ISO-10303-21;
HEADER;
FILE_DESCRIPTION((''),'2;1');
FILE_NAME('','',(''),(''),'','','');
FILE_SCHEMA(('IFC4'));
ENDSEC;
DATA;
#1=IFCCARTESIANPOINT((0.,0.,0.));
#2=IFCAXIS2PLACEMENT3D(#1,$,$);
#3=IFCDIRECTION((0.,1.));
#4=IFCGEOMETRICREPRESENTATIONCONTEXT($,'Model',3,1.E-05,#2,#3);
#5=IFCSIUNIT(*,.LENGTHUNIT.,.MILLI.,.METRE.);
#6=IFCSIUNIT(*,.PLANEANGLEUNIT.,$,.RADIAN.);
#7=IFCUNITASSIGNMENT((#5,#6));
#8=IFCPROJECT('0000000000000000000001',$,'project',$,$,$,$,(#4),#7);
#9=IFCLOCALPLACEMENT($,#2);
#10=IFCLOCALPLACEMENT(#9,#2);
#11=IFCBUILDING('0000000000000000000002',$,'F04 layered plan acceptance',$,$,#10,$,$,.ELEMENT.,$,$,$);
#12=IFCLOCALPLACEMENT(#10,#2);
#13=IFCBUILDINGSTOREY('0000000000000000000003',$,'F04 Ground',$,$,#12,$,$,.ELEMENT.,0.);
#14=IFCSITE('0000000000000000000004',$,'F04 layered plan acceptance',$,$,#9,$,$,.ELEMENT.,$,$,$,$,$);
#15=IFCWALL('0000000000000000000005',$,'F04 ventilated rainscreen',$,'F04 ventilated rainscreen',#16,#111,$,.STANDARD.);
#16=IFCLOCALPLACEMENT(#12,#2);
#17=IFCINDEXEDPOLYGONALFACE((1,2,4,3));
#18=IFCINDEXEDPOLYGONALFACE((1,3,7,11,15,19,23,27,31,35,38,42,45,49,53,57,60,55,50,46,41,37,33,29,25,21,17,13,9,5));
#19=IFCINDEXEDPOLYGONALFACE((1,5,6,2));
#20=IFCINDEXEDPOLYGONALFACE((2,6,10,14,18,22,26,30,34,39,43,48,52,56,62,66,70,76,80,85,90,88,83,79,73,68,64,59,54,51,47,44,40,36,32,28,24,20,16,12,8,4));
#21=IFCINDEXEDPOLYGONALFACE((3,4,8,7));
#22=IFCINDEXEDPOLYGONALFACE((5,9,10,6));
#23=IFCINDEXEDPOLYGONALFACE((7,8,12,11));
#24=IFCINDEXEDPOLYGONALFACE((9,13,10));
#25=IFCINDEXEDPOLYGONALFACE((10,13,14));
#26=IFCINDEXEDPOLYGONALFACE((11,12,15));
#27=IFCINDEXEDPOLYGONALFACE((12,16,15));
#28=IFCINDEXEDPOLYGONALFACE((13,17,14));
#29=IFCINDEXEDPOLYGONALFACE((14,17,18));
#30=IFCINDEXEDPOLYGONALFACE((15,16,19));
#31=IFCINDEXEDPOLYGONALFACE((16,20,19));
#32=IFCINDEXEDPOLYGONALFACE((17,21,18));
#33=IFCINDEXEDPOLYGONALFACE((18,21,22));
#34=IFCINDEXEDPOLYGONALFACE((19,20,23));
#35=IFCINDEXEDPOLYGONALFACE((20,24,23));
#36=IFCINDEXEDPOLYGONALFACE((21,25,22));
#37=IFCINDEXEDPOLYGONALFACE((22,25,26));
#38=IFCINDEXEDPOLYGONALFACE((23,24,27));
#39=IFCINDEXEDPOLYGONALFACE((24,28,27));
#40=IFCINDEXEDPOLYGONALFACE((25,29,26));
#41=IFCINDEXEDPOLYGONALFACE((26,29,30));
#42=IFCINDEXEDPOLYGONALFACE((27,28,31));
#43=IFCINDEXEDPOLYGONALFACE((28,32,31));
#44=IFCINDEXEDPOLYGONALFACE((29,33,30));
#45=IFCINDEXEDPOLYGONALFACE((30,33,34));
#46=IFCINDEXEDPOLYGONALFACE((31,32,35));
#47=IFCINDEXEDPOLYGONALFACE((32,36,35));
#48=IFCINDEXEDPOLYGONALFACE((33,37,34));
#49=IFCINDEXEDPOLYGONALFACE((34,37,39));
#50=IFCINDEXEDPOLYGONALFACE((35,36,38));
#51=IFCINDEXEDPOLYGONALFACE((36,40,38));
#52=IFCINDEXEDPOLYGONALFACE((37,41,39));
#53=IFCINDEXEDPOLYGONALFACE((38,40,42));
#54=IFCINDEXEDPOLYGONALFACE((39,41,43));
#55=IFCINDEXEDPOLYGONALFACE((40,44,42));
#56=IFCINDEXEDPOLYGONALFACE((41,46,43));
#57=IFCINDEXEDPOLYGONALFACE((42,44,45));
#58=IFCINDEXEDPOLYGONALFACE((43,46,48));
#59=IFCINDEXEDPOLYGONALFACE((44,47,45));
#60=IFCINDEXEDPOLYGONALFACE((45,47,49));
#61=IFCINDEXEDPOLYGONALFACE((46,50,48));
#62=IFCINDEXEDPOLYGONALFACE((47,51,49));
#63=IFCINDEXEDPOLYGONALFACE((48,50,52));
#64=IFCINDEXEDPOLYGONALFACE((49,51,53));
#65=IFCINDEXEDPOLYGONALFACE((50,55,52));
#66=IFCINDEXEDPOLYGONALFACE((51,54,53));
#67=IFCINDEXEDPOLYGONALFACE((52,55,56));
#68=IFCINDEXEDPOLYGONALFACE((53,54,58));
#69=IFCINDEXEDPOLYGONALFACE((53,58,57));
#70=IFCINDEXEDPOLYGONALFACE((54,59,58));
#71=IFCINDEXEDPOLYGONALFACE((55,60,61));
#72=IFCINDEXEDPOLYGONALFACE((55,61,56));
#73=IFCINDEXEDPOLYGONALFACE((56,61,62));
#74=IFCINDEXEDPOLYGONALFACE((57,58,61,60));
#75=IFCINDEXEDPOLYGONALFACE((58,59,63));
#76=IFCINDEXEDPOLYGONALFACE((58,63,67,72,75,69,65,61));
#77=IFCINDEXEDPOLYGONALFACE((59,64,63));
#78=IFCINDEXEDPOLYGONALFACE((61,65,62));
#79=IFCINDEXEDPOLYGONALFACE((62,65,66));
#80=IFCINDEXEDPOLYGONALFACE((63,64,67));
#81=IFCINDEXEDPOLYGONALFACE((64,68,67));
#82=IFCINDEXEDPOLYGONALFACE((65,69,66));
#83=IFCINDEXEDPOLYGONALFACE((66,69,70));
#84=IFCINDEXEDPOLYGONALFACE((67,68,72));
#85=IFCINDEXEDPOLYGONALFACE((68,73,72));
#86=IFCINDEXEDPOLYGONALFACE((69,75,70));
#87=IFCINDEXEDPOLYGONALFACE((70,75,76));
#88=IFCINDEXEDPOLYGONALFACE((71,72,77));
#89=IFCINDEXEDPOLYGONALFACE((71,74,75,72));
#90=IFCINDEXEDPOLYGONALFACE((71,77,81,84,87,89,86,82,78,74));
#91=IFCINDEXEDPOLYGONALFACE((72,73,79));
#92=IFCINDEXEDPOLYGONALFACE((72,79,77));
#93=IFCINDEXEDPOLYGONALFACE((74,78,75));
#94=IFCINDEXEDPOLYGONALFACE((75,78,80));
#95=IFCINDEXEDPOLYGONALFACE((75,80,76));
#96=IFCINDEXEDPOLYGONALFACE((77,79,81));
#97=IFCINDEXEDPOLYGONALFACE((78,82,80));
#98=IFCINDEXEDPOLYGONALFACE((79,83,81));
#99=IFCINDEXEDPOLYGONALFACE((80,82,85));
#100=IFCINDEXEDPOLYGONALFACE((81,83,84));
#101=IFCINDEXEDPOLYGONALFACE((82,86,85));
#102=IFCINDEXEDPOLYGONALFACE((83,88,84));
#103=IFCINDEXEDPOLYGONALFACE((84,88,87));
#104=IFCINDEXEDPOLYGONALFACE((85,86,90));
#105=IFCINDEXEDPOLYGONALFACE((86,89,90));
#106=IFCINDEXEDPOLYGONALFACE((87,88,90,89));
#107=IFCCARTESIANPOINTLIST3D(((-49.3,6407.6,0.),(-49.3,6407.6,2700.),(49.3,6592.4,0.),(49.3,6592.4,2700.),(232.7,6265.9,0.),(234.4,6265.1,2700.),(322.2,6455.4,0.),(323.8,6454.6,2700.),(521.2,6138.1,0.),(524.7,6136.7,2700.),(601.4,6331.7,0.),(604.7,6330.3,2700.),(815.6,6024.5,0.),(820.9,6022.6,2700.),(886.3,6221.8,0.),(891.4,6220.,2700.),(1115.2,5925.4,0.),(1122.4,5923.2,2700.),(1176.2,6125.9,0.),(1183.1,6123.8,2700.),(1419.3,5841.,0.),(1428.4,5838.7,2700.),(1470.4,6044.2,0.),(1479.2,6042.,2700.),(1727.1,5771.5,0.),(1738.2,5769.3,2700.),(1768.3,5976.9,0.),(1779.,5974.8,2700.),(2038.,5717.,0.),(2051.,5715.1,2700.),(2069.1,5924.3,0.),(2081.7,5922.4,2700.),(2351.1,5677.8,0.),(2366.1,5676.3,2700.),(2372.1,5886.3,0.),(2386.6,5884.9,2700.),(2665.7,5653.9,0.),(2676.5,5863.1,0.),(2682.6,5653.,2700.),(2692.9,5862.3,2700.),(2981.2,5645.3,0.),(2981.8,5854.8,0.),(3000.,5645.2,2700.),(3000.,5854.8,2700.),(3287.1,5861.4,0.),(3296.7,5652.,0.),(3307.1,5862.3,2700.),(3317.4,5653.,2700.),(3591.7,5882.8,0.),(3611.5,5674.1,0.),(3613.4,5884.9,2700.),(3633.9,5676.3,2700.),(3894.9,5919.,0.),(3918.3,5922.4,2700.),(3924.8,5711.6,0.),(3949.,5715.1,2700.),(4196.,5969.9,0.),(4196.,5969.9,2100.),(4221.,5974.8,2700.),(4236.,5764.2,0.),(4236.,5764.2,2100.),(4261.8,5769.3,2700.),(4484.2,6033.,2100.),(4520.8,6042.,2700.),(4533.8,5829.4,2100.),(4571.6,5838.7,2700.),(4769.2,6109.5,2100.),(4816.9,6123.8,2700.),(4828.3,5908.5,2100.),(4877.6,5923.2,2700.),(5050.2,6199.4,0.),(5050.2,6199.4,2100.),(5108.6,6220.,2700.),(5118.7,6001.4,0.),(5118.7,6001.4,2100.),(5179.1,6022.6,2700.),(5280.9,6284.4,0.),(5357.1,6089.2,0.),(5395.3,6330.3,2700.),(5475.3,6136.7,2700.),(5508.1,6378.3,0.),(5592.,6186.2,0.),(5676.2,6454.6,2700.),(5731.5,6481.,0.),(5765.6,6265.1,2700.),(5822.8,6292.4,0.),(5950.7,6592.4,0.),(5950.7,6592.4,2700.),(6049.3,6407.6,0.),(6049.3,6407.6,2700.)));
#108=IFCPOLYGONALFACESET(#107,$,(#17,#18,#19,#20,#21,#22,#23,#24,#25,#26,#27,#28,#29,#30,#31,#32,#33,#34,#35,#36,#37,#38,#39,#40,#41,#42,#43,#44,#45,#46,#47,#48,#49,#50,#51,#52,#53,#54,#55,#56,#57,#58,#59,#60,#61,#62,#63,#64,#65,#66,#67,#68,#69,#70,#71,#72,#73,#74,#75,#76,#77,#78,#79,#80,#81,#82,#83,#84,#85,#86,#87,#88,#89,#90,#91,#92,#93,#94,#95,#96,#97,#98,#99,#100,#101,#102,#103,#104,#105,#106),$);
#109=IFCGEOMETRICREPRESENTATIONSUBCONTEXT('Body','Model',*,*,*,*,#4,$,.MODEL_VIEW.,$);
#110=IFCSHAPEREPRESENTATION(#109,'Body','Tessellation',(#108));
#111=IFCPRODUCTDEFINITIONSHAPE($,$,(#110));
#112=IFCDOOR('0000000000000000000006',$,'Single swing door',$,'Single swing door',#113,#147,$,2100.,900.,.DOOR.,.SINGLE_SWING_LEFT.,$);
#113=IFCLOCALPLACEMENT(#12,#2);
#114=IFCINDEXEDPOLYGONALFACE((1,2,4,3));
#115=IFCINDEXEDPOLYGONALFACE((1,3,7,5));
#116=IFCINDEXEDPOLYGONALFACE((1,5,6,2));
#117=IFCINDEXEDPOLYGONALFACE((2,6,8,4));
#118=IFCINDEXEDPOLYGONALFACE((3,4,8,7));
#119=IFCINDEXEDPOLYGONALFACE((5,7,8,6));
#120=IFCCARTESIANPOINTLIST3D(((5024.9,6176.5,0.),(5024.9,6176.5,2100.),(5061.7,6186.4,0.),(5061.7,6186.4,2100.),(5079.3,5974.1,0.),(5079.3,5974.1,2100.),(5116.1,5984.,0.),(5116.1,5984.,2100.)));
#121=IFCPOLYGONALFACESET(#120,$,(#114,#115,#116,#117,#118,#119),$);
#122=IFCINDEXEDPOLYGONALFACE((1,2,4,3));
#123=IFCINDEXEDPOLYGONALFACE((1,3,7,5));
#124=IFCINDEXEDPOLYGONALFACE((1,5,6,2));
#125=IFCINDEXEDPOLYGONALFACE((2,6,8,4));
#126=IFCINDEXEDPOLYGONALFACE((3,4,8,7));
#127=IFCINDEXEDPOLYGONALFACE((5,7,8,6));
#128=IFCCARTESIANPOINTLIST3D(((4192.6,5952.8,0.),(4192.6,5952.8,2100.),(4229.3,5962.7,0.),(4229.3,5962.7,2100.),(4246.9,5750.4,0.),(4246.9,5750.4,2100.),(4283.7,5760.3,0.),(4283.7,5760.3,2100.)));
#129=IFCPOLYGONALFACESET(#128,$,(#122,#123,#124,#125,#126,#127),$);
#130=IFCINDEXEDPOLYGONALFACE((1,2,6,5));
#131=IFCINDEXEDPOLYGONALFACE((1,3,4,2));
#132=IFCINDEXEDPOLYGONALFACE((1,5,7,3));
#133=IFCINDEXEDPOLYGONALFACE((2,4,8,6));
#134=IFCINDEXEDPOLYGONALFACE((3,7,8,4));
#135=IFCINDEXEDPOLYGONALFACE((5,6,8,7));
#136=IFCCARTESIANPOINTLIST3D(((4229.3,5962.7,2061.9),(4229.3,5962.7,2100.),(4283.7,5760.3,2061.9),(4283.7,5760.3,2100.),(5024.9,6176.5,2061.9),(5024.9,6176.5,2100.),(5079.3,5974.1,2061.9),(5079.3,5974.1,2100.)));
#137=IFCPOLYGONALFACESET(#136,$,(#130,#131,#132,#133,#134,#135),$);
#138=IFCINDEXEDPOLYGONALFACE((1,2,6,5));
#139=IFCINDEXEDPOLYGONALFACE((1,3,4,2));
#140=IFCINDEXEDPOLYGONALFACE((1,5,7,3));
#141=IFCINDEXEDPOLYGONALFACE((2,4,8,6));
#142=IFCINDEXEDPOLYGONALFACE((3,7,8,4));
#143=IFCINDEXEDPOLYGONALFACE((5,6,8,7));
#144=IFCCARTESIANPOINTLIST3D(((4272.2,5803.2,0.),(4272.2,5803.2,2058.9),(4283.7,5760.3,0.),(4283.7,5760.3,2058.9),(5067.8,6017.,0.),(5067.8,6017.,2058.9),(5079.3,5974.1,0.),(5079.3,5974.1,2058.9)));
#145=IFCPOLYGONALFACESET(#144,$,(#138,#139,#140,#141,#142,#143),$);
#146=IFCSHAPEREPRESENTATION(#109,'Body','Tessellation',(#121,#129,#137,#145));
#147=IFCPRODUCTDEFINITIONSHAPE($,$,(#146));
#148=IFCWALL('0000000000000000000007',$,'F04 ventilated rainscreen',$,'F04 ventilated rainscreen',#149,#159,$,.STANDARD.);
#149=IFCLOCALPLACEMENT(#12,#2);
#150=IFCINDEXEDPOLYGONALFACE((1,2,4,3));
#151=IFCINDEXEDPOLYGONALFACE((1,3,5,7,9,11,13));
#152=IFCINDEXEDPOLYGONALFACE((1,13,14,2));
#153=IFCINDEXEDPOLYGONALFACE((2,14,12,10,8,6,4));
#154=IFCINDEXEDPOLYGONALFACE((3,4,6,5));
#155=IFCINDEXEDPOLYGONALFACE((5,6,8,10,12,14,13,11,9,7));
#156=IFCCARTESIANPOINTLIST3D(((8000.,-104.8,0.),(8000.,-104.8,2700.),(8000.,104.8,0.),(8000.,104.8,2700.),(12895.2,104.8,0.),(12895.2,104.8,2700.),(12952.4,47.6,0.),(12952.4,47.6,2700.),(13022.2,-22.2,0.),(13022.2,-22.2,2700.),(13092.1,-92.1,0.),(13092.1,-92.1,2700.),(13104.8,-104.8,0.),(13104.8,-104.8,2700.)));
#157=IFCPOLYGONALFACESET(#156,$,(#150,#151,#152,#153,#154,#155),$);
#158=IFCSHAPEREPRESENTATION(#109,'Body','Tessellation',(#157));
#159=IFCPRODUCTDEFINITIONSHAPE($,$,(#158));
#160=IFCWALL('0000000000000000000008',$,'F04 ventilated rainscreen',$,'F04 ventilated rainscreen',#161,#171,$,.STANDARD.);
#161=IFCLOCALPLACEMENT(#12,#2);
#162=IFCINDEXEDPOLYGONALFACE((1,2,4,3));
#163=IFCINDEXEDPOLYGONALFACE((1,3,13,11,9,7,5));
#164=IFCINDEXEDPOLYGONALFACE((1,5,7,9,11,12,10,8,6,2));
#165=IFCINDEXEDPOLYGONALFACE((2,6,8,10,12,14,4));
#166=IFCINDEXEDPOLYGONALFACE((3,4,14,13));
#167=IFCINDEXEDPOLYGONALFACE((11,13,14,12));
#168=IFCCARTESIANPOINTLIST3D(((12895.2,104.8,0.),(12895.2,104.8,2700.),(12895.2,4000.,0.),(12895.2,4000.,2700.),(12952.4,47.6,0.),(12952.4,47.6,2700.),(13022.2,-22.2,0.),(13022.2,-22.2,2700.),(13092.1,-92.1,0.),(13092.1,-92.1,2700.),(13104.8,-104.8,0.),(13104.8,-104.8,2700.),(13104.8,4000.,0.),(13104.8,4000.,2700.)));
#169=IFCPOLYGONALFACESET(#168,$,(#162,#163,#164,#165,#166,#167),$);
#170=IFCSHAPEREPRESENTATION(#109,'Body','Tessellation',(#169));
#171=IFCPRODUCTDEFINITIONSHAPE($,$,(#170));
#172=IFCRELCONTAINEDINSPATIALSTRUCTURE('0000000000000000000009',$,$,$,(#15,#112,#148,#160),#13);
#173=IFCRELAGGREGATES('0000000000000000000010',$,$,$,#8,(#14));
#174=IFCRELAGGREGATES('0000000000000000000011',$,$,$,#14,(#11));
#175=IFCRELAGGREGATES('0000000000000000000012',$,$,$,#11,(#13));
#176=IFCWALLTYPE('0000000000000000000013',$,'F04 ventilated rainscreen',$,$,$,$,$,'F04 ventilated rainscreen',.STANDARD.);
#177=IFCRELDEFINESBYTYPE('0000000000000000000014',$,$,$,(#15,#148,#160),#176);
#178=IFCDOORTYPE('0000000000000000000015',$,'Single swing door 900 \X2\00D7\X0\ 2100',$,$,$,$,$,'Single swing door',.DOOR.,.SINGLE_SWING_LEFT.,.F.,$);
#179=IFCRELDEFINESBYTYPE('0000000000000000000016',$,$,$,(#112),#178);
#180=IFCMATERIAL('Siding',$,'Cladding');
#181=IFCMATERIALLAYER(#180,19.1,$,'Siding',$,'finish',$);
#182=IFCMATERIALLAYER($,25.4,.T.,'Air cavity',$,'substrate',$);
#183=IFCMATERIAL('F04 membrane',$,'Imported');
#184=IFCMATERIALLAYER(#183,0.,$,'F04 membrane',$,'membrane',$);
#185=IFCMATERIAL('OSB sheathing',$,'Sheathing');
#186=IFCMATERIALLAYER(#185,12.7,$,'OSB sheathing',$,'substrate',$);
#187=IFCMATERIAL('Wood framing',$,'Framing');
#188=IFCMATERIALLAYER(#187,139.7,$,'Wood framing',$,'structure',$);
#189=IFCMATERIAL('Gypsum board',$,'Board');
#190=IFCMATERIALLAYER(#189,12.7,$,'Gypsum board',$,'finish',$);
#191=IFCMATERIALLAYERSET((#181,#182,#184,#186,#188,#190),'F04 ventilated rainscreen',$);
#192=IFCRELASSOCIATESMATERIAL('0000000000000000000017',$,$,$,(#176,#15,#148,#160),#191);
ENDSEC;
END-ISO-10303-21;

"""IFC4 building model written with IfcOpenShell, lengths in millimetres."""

from ifc_helpers import new_model, si_unit, direction, frame, origin, origin_with_axes, place, context, subcontext, project, spatial, polyline, line, arc, indexed_curve, outline, extrude, material, layer, layer_set, layer_usage, type_object, element, fill, save


model = new_model("IFC4")

# Units and contexts
model_context = context("Model", 3, precision=1e-05, world=origin(), true_north=direction((0.0, 1.0)))
body_context = subcontext(model_context, "Body", "Model", "MODEL_VIEW")
ifc_project = project(units=[si_unit("LENGTHUNIT", "METRE", prefix="MILLI"), si_unit("PLANEANGLEUNIT", "RADIAN")], contexts=[model_context])

# Site, building, storey
site_placement = place(None, origin())
site = spatial("IfcSite", under=ifc_project, at=site_placement, Name="F04 layered plan acceptance", CompositionType="ELEMENT")
building_placement = place(site_placement, origin())
building = spatial("IfcBuilding", under=site, at=building_placement, Name="F04 layered plan acceptance", CompositionType="ELEMENT")
storey_placement = place(building_placement, origin())
storey = spatial("IfcBuildingStorey", under=building, at=storey_placement, Name="F04 Ground", CompositionType="ELEMENT", Elevation=0.0)

# Shared definitions
ifc_material_1 = material(Name="Siding", Category="Cladding")
ifc_layer_1 = layer(ifc_material_1, 19.1, Name="Siding", Category="finish")
ifc_layer_2 = layer(None, 25.4, ventilated=True, Name="Air cavity", Category="substrate")
ifc_material_2 = material(Name="F04 membrane", Category="Imported")
ifc_layer_3 = layer(ifc_material_2, 0.0, Name="F04 membrane", Category="membrane")
ifc_material_3 = material(Name="OSB sheathing", Category="Sheathing")
ifc_layer_4 = layer(ifc_material_3, 12.7, Name="OSB sheathing", Category="substrate")
ifc_material_4 = material(Name="Wood framing", Category="Framing")
ifc_layer_5 = layer(ifc_material_4, 139.7, Name="Wood framing", Category="structure")
ifc_material_5 = material(Name="Gypsum board", Category="Board")
ifc_layer_6 = layer(ifc_material_5, 12.7, Name="Gypsum board", Category="finish")
ifc_layer_set_1 = layer_set([ifc_layer_1, ifc_layer_2, ifc_layer_3, ifc_layer_4, ifc_layer_5, ifc_layer_6], Name="F04 ventilated rainscreen")
wall_type_1 = type_object("IfcWallType", Name="F04 ventilated rainscreen", ElementType="F04 ventilated rainscreen", PredefinedType="STANDARD", material=ifc_layer_set_1)
door_type = type_object("IfcDoorType", Name="Single swing door 900 × 2100", ElementType="Single swing door", OperationType="SINGLE_SWING_LEFT", ParameterTakesPrecedence=False, PredefinedType="DOOR")

# Wall, opening, door
ifc_layer_usage_1 = layer_usage(ifc_layer_set_1, "AXIS2", "POSITIVE", -104.8)
wall_1_placement = place(storey_placement, frame((6000.0, 6500.0, 0.0), z_axis=(0.0, 0.0, 1.0), x_axis=(-1.0, 0.0, 0.0)))
wall_1 = element("IfcWall", 1, at=wall_1_placement, inside=storey, type_object=wall_type_1, material=ifc_layer_usage_1, Name="F04 ventilated rainscreen", ObjectType="F04 ventilated rainscreen", PredefinedType="STANDARD", context=body_context, shape_type="SweptSolid", body=[
    extrude(outline(indexed_curve([(49.3, -92.4), (3000.0, 645.2), (5950.7, -92.4), (6049.3, 92.4), (3000.0, 854.8), (-49.3, 92.4)], segments=[arc(1, 2, 3), line(3, 4), arc(4, 5, 6), line(6, 1)], self_intersect=False)), origin(), (0.0, 0.0, 1.0), 2700.0),
])
opening_1_placement = place(wall_1_placement, frame((911.1, 414.8, 0.0), z_axis=(0.0, 0.0, 1.0), x_axis=(0.965743, 0.259502, 0.0)))
opening_1 = element("IfcOpeningElement", 2, at=opening_1_placement, cuts=wall_1, PredefinedType="OPENING", context=body_context, shape_type="SweptSolid", body=[
    extrude(outline(polyline([(8.5, -130.4), (891.5, -130.4), (908.9, 114.8), (-8.9, 114.8), (8.5, -130.4)])), origin(), (0.0, 0.0, 1.0), 2100.0),
])
door_1_placement = place(opening_1_placement, origin_with_axes())
door_1 = element("IfcDoor", 3, at=door_1_placement, inside=storey, type_object=door_type, Name="Single swing door", ObjectType="Single swing door", OperationType="SINGLE_SWING_LEFT", OverallHeight=2100.0, OverallWidth=900.0, PredefinedType="DOOR", context=body_context, shape_type="SweptSolid", body=[
    extrude(outline(polyline([(0.0, -104.8), (38.1, -104.8), (38.1, 104.8), (0.0, 104.8), (0.0, -104.8)])), origin(), (0.0, 0.0, 1.0), 2100.0),
    extrude(outline(polyline([(861.9, -104.8), (900.0, -104.8), (900.0, 104.8), (861.9, 104.8), (861.9, -104.8)])), origin(), (0.0, 0.0, 1.0), 2100.0),
    extrude(outline(polyline([(38.1, -104.8), (861.9, -104.8), (861.9, 104.8), (38.1, 104.8), (38.1, -104.8)])), frame((0.0, 0.0, 2061.9)), (0.0, 0.0, 1.0), 38.1),
    extrude(outline(polyline([(38.1, 60.3), (861.9, 60.3), (861.9, 104.8), (38.1, 104.8), (38.1, 60.3)])), origin(), (0.0, 0.0, 1.0), 2058.9),
])
fill(opening_1, door_1)

# Walls
ifc_layer_usage_2 = layer_usage(ifc_layer_set_1, "AXIS2", "NEGATIVE", 104.8)
wall_2_placement = place(storey_placement, frame((8000.0, 0.0, 0.0), z_axis=(0.0, 0.0, 1.0), x_axis=(1.0, 0.0, 0.0)))
element("IfcWall", 4, at=wall_2_placement, inside=storey, type_object=wall_type_1, material=ifc_layer_usage_2, Name="F04 ventilated rainscreen", ObjectType="F04 ventilated rainscreen", PredefinedType="STANDARD", context=body_context, shape_type="SweptSolid", body=[
    extrude(outline(polyline([(0.0, -104.8), (5104.8, -104.8), (5092.1, -92.1), (5022.2, -22.2), (4952.4, 47.6), (4895.2, 104.8), (0.0, 104.8), (0.0, -104.8)])), origin(), (0.0, 0.0, 1.0), 2700.0),
])
ifc_layer_usage_3 = layer_usage(ifc_layer_set_1, "AXIS2", "NEGATIVE", 104.8)
wall_3_placement = place(storey_placement, frame((13000.0, 0.0, 0.0), z_axis=(0.0, 0.0, 1.0), x_axis=(0.0, 1.0, 0.0)))
element("IfcWall", 5, at=wall_3_placement, inside=storey, type_object=wall_type_1, material=ifc_layer_usage_3, Name="F04 ventilated rainscreen", ObjectType="F04 ventilated rainscreen", PredefinedType="STANDARD", context=body_context, shape_type="SweptSolid", body=[
    extrude(outline(polyline([(-104.8, -104.8), (4000.0, -104.8), (4000.0, 104.8), (104.8, 104.8), (47.6, 47.6), (-22.2, -22.2), (-92.1, -92.1), (-104.8, -104.8)])), origin(), (0.0, 0.0, 1.0), 2700.0),
])

save(model, "model.ifc")
